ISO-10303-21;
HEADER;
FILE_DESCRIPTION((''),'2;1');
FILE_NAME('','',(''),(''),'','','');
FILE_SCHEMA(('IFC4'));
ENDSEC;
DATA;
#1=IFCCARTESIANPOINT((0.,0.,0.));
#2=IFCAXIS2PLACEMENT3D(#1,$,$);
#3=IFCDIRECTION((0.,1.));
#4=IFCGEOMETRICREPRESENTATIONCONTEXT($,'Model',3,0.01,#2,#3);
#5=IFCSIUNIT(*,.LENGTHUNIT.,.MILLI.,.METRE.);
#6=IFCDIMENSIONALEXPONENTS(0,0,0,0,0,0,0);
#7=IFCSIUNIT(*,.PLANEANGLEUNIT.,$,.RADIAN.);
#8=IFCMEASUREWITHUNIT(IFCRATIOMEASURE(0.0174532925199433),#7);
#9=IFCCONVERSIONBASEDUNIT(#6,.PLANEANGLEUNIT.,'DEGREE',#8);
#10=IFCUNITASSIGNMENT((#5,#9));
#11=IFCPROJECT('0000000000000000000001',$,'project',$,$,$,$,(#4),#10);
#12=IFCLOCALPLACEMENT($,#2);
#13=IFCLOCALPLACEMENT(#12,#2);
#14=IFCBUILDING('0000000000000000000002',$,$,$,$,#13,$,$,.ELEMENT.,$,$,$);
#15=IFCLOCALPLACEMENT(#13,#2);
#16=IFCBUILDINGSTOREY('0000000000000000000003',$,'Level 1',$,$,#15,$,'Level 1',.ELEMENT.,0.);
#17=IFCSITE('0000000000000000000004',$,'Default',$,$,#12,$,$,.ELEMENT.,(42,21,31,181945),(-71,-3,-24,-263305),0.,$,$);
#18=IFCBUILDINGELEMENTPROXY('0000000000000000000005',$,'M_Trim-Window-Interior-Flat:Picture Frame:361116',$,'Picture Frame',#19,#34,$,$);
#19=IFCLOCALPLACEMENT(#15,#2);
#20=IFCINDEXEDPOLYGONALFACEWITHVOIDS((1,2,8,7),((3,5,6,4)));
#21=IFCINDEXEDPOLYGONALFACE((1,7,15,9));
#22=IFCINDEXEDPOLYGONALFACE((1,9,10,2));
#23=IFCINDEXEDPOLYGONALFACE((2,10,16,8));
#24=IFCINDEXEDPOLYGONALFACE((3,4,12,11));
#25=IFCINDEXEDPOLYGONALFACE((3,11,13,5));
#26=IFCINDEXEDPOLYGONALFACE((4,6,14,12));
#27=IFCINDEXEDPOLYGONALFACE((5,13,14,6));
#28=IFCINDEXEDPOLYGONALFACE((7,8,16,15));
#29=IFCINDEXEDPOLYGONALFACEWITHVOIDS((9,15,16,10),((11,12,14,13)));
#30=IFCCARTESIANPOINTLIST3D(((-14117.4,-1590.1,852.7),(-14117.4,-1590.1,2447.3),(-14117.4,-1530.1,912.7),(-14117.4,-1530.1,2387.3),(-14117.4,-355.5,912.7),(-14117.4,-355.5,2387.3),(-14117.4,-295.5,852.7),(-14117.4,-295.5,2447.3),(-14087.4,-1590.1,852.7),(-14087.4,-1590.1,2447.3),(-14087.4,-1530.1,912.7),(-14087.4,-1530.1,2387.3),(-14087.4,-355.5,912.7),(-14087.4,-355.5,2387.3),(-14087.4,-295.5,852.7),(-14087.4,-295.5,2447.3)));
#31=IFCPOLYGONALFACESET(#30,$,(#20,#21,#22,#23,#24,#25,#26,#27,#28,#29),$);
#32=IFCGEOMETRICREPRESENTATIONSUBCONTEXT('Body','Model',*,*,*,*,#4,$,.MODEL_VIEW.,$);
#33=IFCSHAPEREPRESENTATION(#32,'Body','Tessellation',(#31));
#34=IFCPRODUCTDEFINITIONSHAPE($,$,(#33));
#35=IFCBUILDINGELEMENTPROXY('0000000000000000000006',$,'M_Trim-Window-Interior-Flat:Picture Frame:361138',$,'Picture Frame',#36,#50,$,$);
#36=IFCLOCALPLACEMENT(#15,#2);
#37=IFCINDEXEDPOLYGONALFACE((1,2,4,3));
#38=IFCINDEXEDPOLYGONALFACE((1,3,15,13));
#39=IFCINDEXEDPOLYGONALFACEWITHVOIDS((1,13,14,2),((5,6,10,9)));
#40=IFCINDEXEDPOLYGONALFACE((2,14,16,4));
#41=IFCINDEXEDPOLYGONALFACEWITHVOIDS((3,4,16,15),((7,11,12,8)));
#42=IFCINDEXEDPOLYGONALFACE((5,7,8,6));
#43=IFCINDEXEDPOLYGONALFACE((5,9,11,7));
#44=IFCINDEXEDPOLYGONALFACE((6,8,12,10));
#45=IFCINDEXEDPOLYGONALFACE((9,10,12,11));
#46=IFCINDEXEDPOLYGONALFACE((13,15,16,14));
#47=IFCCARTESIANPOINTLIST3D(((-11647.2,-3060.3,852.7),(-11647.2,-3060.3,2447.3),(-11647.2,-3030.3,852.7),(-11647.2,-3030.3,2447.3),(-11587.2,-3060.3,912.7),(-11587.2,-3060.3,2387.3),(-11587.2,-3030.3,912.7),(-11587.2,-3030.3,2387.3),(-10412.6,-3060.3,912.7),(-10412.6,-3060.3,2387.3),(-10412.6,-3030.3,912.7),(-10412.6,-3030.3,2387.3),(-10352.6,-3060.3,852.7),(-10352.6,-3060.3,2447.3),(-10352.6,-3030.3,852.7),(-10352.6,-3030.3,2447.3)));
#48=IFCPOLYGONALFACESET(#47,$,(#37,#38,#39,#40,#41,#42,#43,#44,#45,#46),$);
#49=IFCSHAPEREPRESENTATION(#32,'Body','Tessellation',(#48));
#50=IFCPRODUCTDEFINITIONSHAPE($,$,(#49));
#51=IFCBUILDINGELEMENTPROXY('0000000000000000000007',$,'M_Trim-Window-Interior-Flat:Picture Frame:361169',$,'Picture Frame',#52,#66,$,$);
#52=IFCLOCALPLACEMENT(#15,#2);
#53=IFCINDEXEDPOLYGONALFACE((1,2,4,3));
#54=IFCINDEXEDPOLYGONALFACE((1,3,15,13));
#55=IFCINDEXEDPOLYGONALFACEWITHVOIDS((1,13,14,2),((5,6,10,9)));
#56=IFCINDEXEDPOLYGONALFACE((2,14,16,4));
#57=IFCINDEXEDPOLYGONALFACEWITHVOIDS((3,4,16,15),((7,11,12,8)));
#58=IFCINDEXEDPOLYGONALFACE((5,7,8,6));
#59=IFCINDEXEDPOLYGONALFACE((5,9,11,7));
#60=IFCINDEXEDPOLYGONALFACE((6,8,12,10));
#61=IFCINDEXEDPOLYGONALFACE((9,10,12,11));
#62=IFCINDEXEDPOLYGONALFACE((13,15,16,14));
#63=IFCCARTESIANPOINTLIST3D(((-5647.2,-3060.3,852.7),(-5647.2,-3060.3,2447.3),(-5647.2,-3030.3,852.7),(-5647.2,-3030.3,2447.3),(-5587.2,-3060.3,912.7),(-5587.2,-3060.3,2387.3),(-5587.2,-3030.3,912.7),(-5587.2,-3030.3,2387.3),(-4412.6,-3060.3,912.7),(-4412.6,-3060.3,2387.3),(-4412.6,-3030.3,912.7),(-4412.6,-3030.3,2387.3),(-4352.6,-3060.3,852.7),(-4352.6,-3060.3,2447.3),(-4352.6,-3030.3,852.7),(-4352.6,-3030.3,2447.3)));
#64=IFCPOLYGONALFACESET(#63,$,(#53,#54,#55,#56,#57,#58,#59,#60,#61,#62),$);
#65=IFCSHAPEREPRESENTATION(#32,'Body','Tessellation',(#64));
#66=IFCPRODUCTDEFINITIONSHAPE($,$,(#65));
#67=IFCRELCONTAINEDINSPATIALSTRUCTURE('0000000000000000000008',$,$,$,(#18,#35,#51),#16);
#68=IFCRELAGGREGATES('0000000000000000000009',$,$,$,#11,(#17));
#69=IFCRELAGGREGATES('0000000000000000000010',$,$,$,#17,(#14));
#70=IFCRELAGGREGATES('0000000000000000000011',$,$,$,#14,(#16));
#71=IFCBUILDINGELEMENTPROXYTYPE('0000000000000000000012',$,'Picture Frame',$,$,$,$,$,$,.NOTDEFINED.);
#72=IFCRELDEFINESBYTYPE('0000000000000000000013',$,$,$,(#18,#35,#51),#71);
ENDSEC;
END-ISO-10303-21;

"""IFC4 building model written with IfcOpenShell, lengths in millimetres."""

from ifc_helpers import new_model, entity, si_unit, converted_unit, direction, frame, origin, place, context, subcontext, project, spatial, polyline, outline, extrude, source, transform, mapped, type_object, type_shapes, element, save


model = new_model("IFC4")

# Units and contexts
model_context = context("Model", 3, precision=0.01, world=origin(), true_north=direction((0.0, 1.0)))
body_context = subcontext(model_context, "Body", "Model", "MODEL_VIEW")
ifc_project = project(units=[si_unit("LENGTHUNIT", "METRE", prefix="MILLI"), converted_unit("PLANEANGLEUNIT", "DEGREE", entity("IfcRatioMeasure", 0.0174532925199433), si_unit("PLANEANGLEUNIT", "RADIAN"), dimensions=[0, 0, 0, 0, 0, 0, 0])], contexts=[model_context])

# Site, building, storey
site_placement = place(None, origin())
site = spatial("IfcSite", under=ifc_project, at=site_placement, Name="Default", CompositionType="ELEMENT", RefLatitude=(42, 21, 31, 181945), RefLongitude=(-71, -3, -24, -263305), RefElevation=0.0)
building_placement = place(site_placement, origin())
building = spatial("IfcBuilding", under=site, at=building_placement, CompositionType="ELEMENT")
storey_placement = place(building_placement, origin())
storey = spatial("IfcBuildingStorey", under=building, at=storey_placement, Name="Level 1", LongName="Level 1", CompositionType="ELEMENT", Elevation=0.0)

# Building element proxies
building_element_proxy_type_1 = type_object("IfcBuildingElementProxyType", Name="Picture Frame", PredefinedType="NOTDEFINED")
shared_shape_1 = source(origin(), body_context, "Body", "SweptSolid", [
    extrude(outline(polyline([(-647.3, -797.3), (647.3, -797.3), (647.3, 797.3), (-647.3, 797.3), (-647.3, -797.3)]), holes=[polyline([(-587.3, -737.3), (-587.3, 737.3), (587.3, 737.3), (587.3, -737.3), (-587.3, -737.3)])]), frame((0.0, -750.0, 0.0), z_axis=(0.0, 0.0, 1.0), x_axis=(-1.0, 0.0, 0.0)), (0.0, 0.0, 1.0), 30.0),
])
type_shapes(building_element_proxy_type_1, [shared_shape_1])
for number, where, z_axis, x_axis, name in (
    (1, (-14087.4, -942.8, 2400.0), (-1.0, 0.0, 0.0), (0.0, -1.0, 0.0), "M_Trim-Window-Interior-Flat:Picture Frame:361116"),
    (2, (-10999.9, -3030.3, 2400.0), (0.0, -1.0, 0.0), (1.0, 0.0, 0.0), "M_Trim-Window-Interior-Flat:Picture Frame:361138"),
    (3, (-4999.9, -3030.3, 2400.0), (0.0, -1.0, 0.0), (1.0, 0.0, 0.0), "M_Trim-Window-Interior-Flat:Picture Frame:361169"),
):
    element("IfcBuildingElementProxy", number, at=place(storey_placement, frame(where, z_axis=z_axis, x_axis=x_axis)), inside=storey, type_object=building_element_proxy_type_1, Name=name, ObjectType="Picture Frame", context=body_context, shape_type="MappedRepresentation", body=[
        mapped(shared_shape_1, transform((0.0, 0.0, 0.0), scale=1.0)),
    ])

save(model, "model.ifc")
